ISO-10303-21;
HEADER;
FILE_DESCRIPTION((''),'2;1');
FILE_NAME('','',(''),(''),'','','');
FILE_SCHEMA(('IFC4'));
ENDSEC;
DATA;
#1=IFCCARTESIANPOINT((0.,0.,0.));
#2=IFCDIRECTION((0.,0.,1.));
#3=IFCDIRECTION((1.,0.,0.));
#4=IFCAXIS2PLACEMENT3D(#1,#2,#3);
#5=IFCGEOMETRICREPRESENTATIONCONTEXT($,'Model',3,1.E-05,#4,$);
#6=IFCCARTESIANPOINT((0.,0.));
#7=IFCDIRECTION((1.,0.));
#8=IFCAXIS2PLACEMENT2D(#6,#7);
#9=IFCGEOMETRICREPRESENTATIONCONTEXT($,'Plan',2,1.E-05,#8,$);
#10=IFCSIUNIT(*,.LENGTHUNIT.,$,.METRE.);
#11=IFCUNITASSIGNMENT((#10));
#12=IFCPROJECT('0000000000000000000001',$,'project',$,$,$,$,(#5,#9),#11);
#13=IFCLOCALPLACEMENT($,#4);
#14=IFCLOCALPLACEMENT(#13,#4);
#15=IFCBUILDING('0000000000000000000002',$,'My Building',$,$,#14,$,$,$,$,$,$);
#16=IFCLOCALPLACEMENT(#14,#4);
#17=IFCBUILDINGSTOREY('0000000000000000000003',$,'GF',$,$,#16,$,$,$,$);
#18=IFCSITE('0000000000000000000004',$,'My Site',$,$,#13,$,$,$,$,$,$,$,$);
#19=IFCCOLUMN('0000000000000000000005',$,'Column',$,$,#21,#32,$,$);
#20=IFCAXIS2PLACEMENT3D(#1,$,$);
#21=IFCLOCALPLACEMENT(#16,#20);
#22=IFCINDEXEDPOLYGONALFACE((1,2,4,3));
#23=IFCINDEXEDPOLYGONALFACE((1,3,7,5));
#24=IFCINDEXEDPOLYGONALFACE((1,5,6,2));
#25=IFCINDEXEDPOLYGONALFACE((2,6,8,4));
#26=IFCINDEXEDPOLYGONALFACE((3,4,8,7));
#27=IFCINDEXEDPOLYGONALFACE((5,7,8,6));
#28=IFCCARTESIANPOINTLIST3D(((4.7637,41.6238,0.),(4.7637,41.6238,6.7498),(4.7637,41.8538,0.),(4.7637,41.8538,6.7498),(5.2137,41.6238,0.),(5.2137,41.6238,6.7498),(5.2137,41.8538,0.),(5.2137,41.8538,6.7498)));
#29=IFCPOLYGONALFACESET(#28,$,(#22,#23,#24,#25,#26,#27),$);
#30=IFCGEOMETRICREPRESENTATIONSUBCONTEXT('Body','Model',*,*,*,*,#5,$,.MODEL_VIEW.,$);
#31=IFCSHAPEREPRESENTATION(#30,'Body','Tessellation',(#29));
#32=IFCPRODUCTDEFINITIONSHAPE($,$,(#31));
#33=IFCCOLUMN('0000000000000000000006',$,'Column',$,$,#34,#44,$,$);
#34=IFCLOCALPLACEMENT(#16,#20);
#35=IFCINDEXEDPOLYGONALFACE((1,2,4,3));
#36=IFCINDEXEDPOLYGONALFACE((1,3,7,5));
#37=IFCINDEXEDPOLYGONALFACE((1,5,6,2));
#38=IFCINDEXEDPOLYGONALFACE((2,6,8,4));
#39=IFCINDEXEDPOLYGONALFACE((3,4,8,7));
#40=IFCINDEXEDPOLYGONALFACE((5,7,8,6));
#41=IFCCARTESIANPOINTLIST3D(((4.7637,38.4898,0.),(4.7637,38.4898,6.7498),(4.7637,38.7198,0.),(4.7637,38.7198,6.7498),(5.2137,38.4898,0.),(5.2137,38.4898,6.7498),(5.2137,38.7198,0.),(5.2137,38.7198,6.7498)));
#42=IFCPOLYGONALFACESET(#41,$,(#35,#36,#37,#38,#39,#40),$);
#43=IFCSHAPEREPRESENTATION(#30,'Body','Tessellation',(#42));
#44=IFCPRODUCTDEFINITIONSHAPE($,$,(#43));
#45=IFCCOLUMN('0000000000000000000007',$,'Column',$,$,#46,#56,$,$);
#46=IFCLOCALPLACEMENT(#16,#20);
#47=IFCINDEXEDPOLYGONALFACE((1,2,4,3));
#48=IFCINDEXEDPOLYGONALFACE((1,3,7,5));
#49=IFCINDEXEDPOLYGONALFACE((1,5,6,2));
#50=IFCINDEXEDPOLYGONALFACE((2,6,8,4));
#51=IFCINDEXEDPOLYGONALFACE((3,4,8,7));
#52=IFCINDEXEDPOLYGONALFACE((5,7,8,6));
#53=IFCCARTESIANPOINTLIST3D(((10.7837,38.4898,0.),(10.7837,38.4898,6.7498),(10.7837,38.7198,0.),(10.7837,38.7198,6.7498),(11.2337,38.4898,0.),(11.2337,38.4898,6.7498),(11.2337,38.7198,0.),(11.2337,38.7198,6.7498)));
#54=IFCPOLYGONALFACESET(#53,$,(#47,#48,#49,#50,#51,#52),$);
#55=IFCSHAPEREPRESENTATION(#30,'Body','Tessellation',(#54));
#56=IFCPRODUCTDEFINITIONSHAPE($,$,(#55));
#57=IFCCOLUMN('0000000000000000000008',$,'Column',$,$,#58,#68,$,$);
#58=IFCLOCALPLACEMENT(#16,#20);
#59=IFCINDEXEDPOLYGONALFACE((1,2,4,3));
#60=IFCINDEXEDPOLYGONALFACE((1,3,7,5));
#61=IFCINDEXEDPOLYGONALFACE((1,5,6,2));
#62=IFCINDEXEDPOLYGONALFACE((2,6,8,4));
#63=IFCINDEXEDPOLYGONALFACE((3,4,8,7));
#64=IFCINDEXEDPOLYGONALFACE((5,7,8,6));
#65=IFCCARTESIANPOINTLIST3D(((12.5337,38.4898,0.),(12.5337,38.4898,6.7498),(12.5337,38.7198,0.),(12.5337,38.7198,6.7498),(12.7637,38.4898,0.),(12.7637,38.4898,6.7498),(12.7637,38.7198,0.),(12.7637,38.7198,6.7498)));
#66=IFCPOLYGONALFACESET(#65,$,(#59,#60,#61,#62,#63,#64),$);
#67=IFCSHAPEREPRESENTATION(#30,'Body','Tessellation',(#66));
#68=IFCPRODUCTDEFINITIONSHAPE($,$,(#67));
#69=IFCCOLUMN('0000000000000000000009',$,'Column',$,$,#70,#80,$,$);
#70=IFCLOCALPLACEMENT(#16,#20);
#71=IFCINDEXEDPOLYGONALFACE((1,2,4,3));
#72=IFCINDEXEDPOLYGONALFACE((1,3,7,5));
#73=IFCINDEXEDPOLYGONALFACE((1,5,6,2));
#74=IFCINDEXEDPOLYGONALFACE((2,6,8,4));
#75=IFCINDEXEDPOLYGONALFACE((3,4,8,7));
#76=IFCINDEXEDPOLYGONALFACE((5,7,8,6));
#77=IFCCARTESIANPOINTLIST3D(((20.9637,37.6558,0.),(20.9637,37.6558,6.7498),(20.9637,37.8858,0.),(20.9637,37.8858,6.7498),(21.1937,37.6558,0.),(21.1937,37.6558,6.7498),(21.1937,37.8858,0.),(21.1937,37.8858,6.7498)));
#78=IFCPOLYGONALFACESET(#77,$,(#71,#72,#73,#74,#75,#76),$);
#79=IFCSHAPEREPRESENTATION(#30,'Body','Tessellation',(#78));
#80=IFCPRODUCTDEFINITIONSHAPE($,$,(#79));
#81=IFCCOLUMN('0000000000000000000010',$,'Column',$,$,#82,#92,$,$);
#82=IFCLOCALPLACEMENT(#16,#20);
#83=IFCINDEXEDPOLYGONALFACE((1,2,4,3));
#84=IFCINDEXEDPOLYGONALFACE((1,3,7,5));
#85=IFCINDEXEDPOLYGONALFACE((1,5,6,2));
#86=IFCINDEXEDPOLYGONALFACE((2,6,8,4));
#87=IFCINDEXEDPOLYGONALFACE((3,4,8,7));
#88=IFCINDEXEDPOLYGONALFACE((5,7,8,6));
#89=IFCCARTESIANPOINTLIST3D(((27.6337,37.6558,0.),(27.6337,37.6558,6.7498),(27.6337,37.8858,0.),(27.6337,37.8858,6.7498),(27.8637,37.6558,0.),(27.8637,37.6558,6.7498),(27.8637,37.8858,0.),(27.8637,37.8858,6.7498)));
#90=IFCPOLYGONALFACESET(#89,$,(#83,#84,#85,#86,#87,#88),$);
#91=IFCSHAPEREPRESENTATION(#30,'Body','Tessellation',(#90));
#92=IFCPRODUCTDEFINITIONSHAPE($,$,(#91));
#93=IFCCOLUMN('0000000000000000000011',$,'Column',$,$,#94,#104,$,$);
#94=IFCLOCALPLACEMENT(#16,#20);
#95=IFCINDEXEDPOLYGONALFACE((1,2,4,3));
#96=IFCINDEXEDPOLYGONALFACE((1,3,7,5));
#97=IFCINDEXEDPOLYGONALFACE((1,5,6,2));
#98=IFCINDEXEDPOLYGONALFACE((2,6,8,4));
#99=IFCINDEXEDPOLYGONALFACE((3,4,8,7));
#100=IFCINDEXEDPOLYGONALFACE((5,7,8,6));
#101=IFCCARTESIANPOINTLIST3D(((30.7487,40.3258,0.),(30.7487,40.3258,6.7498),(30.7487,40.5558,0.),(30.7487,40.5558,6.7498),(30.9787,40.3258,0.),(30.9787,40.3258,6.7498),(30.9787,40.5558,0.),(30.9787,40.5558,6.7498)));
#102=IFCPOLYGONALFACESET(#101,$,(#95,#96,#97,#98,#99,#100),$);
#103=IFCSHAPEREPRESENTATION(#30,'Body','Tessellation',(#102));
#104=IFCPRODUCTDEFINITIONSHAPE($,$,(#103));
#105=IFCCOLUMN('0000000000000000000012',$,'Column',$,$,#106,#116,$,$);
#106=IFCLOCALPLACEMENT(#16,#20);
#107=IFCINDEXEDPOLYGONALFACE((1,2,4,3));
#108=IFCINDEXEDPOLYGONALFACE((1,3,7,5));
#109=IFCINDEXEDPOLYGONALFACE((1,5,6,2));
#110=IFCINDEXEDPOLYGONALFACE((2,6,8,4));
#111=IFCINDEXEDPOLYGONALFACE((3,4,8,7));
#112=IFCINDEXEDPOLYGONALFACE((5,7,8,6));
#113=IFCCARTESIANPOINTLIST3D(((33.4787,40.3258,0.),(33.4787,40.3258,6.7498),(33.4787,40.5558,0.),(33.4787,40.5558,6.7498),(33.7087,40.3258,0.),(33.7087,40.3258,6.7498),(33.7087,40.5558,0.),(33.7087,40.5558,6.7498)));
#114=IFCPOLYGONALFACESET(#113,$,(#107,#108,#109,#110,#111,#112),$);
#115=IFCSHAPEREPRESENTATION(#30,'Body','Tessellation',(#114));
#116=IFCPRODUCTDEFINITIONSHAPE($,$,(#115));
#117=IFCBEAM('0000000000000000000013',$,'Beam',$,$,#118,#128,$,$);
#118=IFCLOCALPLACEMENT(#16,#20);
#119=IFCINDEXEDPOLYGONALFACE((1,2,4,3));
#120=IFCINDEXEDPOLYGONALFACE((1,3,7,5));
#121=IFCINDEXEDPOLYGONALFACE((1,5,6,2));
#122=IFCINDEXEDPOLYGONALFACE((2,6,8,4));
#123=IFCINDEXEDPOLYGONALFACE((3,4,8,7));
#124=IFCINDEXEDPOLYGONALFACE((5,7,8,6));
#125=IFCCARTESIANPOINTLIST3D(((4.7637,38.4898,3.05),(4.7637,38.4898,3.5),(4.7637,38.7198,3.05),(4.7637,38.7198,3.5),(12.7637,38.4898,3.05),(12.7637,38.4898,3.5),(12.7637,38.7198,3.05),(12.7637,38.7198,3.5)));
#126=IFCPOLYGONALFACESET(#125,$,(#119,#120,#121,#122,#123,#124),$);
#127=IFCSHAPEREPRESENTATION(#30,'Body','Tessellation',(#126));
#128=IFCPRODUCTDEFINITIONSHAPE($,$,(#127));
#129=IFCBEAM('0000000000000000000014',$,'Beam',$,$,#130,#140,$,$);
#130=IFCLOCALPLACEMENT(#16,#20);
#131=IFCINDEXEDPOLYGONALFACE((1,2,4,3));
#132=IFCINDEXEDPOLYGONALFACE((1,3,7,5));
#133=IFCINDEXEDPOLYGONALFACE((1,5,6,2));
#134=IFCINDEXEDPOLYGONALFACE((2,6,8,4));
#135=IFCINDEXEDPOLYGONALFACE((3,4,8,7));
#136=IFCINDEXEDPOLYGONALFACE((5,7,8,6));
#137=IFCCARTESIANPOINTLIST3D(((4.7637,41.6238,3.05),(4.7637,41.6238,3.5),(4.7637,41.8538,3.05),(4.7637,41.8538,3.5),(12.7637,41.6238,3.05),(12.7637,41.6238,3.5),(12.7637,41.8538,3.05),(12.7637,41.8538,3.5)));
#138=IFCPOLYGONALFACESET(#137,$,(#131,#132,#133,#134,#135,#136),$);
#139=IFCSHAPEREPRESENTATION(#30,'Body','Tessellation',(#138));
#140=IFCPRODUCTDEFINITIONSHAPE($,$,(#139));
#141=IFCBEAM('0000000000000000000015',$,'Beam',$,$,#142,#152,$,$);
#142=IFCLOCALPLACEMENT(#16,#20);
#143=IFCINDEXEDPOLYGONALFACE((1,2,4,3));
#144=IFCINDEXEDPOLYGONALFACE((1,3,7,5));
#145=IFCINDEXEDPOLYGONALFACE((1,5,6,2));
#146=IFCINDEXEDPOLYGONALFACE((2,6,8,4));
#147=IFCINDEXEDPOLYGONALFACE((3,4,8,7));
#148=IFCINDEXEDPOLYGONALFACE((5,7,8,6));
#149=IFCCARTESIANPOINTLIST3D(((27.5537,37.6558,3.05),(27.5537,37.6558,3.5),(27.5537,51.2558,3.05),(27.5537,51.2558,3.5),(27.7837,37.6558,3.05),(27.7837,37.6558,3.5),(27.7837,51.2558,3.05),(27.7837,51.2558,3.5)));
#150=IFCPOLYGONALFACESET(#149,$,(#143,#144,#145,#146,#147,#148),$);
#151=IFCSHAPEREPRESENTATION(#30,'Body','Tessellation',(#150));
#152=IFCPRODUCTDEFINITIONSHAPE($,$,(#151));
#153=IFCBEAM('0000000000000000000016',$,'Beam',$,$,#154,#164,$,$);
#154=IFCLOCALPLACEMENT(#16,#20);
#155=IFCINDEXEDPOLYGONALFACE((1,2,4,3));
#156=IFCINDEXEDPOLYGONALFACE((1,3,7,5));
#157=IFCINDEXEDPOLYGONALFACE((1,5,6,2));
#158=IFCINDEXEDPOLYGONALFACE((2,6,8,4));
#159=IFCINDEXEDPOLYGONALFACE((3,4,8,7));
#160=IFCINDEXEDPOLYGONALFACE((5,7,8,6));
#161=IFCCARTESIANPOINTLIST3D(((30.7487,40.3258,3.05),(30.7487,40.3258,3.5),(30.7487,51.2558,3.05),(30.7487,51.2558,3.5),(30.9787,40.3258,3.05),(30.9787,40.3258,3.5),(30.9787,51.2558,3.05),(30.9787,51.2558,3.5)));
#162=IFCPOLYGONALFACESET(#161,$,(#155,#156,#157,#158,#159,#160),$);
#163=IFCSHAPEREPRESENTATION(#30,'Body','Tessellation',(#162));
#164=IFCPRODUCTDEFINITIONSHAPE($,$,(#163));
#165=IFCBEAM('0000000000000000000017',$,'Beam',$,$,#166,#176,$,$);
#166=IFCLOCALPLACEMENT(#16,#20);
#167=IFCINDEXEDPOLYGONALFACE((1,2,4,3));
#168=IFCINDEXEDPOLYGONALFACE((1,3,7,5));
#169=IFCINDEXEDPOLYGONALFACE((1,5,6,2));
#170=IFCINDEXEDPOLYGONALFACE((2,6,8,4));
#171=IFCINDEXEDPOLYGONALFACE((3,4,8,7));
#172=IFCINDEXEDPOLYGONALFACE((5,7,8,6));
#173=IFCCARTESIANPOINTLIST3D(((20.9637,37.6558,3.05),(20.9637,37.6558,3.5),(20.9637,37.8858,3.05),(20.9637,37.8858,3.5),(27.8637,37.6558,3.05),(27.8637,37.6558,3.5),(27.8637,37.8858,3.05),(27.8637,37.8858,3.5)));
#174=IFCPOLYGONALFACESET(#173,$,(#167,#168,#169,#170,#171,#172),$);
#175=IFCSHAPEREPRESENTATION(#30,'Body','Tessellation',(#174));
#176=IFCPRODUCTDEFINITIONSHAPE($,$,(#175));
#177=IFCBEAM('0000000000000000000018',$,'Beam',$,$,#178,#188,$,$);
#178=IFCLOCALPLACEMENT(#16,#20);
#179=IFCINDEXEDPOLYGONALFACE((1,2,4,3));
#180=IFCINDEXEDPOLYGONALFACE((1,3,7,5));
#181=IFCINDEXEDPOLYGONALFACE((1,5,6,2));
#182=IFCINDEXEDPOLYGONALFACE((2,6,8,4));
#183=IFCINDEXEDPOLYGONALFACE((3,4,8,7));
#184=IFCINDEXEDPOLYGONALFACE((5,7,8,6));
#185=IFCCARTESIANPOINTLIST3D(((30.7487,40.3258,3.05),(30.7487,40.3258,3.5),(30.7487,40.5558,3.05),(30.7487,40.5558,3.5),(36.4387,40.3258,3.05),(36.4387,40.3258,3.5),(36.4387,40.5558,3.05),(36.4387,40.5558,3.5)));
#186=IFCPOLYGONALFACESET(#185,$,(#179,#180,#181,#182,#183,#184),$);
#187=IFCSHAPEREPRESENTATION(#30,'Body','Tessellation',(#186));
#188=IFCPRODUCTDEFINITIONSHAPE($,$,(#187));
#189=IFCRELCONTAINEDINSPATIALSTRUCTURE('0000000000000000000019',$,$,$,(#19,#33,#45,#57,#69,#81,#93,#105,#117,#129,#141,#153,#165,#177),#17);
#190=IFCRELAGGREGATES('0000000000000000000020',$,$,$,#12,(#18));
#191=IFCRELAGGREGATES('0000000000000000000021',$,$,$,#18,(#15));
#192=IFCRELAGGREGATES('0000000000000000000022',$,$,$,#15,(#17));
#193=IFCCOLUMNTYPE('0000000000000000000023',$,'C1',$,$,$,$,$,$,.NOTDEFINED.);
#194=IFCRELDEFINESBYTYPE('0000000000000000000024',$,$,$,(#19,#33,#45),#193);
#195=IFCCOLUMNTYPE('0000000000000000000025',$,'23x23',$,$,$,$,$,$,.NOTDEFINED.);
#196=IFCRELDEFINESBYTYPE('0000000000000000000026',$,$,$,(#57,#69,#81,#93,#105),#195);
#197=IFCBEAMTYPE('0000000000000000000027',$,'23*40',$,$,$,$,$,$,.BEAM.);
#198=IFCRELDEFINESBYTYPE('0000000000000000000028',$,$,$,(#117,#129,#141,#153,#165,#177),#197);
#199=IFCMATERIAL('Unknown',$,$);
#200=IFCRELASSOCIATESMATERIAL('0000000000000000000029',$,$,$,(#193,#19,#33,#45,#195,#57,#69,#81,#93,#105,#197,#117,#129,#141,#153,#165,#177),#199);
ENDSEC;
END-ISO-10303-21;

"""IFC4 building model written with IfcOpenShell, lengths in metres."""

from ifc_helpers import new_model, si_unit, frame, origin_with_axes, origin_2d_with_axis, place, context, subcontext, project, spatial, rectangle, extrude, material, material_profile, profile_set, profile_usage, type_object, element, save


model = new_model("IFC4")

# Units and contexts
model_context = context("Model", 3, precision=1e-05, world=origin_with_axes())
plan_context = context("Plan", 2, precision=1e-05, world=origin_2d_with_axis())
body_context = subcontext(model_context, "Body", "Model", "MODEL_VIEW")
ifc_project = project(units=[si_unit("LENGTHUNIT", "METRE")], contexts=[model_context, plan_context])

# Site, building, storey
site_placement = place(None, origin_with_axes())
site = spatial("IfcSite", under=ifc_project, at=site_placement, Name="My Site")
building_placement = place(site_placement, origin_with_axes())
building = spatial("IfcBuilding", under=site, at=building_placement, Name="My Building")
storey_placement = place(building_placement, origin_with_axes())
storey = spatial("IfcBuildingStorey", under=building, at=storey_placement, Name="GF")

# Columns
ifc_material = material(Name="Unknown")
ifc_material_profile_1 = material_profile(ifc_material, rectangle(XDim=0.45, YDim=0.23))
ifc_profile_set_1 = profile_set([ifc_material_profile_1])
ifc_profile_usage_1 = profile_usage(ifc_profile_set_1, cardinal=5)
column_type_1 = type_object("IfcColumnType", Name="C1", PredefinedType="NOTDEFINED", material=ifc_profile_set_1)
column_1_placement = place(storey_placement, frame((4.9887, 41.7388, 0.0), z_axis=(0.0, 0.0, 1.0), x_axis=(1.0, 0.0, 0.0)))
element("IfcColumn", 1, at=column_1_placement, inside=storey, type_object=column_type_1, material=ifc_profile_usage_1, Name="Column", context=body_context, shape_type="SweptSolid", body=[
    extrude(rectangle(XDim=0.45, YDim=0.23), origin_with_axes(), (0.0, 0.0, 1.0), 6.7498),
])
ifc_profile_usage_2 = profile_usage(ifc_profile_set_1, cardinal=5)
column_2_placement = place(storey_placement, frame((4.9887, 38.6048, 0.0), z_axis=(0.0, 0.0, 1.0), x_axis=(1.0, 0.0, 0.0)))
element("IfcColumn", 2, at=column_2_placement, inside=storey, type_object=column_type_1, material=ifc_profile_usage_2, Name="Column", context=body_context, shape_type="SweptSolid", body=[
    extrude(rectangle(XDim=0.45, YDim=0.23), origin_with_axes(), (0.0, 0.0, 1.0), 6.7498),
])
ifc_profile_usage_3 = profile_usage(ifc_profile_set_1, cardinal=5)
column_3_placement = place(storey_placement, frame((11.0087, 38.6048, 0.0), z_axis=(0.0, 0.0, 1.0), x_axis=(-1.0, 0.0, 0.0)))
element("IfcColumn", 3, at=column_3_placement, inside=storey, type_object=column_type_1, material=ifc_profile_usage_3, Name="Column", context=body_context, shape_type="SweptSolid", body=[
    extrude(rectangle(XDim=0.45, YDim=0.23), origin_with_axes(), (0.0, 0.0, 1.0), 6.7498),
])
ifc_material_profile_2 = material_profile(ifc_material, rectangle(XDim=0.23, YDim=0.23))
ifc_profile_set_2 = profile_set([ifc_material_profile_2])
ifc_profile_usage_4 = profile_usage(ifc_profile_set_2, cardinal=5)
column_type_2 = type_object("IfcColumnType", Name="23x23", PredefinedType="NOTDEFINED", material=ifc_profile_set_2)
column_4_placement = place(storey_placement, frame((12.6487, 38.6048, 0.0), z_axis=(0.0, 0.0, 1.0), x_axis=(1.0, 0.0, 0.0)))
element("IfcColumn", 4, at=column_4_placement, inside=storey, type_object=column_type_2, material=ifc_profile_usage_4, Name="Column", context=body_context, shape_type="SweptSolid", body=[
    extrude(rectangle(XDim=0.23, YDim=0.23), origin_with_axes(), (0.0, 0.0, 1.0), 6.7498),
])
ifc_profile_usage_5 = profile_usage(ifc_profile_set_2, cardinal=5)
column_5_placement = place(storey_placement, frame((21.0787, 37.7708, 0.0), z_axis=(0.0, 0.0, 1.0), x_axis=(1.0, 0.0, 0.0)))
element("IfcColumn", 5, at=column_5_placement, inside=storey, type_object=column_type_2, material=ifc_profile_usage_5, Name="Column", context=body_context, shape_type="SweptSolid", body=[
    extrude(rectangle(XDim=0.23, YDim=0.23), origin_with_axes(), (0.0, 0.0, 1.0), 6.7498),
])
ifc_profile_usage_6 = profile_usage(ifc_profile_set_2, cardinal=5)
column_6_placement = place(storey_placement, frame((27.7487, 37.7708, 0.0), z_axis=(0.0, 0.0, 1.0), x_axis=(1.0, 0.0, 0.0)))
element("IfcColumn", 6, at=column_6_placement, inside=storey, type_object=column_type_2, material=ifc_profile_usage_6, Name="Column", context=body_context, shape_type="SweptSolid", body=[
    extrude(rectangle(XDim=0.23, YDim=0.23), origin_with_axes(), (0.0, 0.0, 1.0), 6.7498),
])
ifc_profile_usage_7 = profile_usage(ifc_profile_set_2, cardinal=5)
column_7_placement = place(storey_placement, frame((30.8637, 40.4408, 0.0), z_axis=(0.0, 0.0, 1.0), x_axis=(1.0, 0.0, 0.0)))
element("IfcColumn", 7, at=column_7_placement, inside=storey, type_object=column_type_2, material=ifc_profile_usage_7, Name="Column", context=body_context, shape_type="SweptSolid", body=[
    extrude(rectangle(XDim=0.23, YDim=0.23), origin_with_axes(), (0.0, 0.0, 1.0), 6.7498),
])
ifc_profile_usage_8 = profile_usage(ifc_profile_set_2, cardinal=5)
column_8_placement = place(storey_placement, frame((33.5937, 40.4408, 0.0), z_axis=(0.0, 0.0, 1.0), x_axis=(1.0, 0.0, 0.0)))
element("IfcColumn", 8, at=column_8_placement, inside=storey, type_object=column_type_2, material=ifc_profile_usage_8, Name="Column", context=body_context, shape_type="SweptSolid", body=[
    extrude(rectangle(XDim=0.23, YDim=0.23), origin_with_axes(), (0.0, 0.0, 1.0), 6.7498),
])

# Beams
ifc_material_profile_3 = material_profile(ifc_material, rectangle(XDim=0.23, YDim=0.45))
ifc_profile_set_3 = profile_set([ifc_material_profile_3])
ifc_profile_usage_9 = profile_usage(ifc_profile_set_3, cardinal=5)
beam_type = type_object("IfcBeamType", Name="23*40", PredefinedType="BEAM", material=ifc_profile_set_3)
beam_1_placement = place(storey_placement, frame((4.7637, 38.6048, 3.275), z_axis=(1.0, 0.0, 0.0), x_axis=(0.0, 1.0, 0.0)))
element("IfcBeam", 9, at=beam_1_placement, inside=storey, type_object=beam_type, material=ifc_profile_usage_9, Name="Beam", context=body_context, shape_type="SweptSolid", body=[
    extrude(rectangle(XDim=0.23, YDim=0.45), origin_with_axes(), (0.0, 0.0, 1.0), 8.0),
])
ifc_profile_usage_10 = profile_usage(ifc_profile_set_3, cardinal=5)
beam_2_placement = place(storey_placement, frame((4.7637, 41.7388, 3.275), z_axis=(1.0, 0.0, 0.0), x_axis=(0.0, 1.0, 0.0)))
element("IfcBeam", 10, at=beam_2_placement, inside=storey, type_object=beam_type, material=ifc_profile_usage_10, Name="Beam", context=body_context, shape_type="SweptSolid", body=[
    extrude(rectangle(XDim=0.23, YDim=0.45), origin_with_axes(), (0.0, 0.0, 1.0), 8.0),
])
ifc_profile_usage_11 = profile_usage(ifc_profile_set_3, cardinal=5)
beam_3_placement = place(storey_placement, frame((27.6687, 37.6558, 3.275), z_axis=(0.0, 1.0, 0.0), x_axis=(-1.0, 0.0, 0.0)))
element("IfcBeam", 11, at=beam_3_placement, inside=storey, type_object=beam_type, material=ifc_profile_usage_11, Name="Beam", context=body_context, shape_type="SweptSolid", body=[
    extrude(rectangle(XDim=0.23, YDim=0.45), origin_with_axes(), (0.0, 0.0, 1.0), 13.6),
])
ifc_profile_usage_12 = profile_usage(ifc_profile_set_3, cardinal=5)
beam_4_placement = place(storey_placement, frame((30.8637, 40.3258, 3.275), z_axis=(0.0, 1.0, 0.0), x_axis=(-1.0, 0.0, 0.0)))
element("IfcBeam", 12, at=beam_4_placement, inside=storey, type_object=beam_type, material=ifc_profile_usage_12, Name="Beam", context=body_context, shape_type="SweptSolid", body=[
    extrude(rectangle(XDim=0.23, YDim=0.45), origin_with_axes(), (0.0, 0.0, 1.0), 10.93),
])
ifc_profile_usage_13 = profile_usage(ifc_profile_set_3, cardinal=5)
beam_5_placement = place(storey_placement, frame((20.9637, 37.7708, 3.275), z_axis=(1.0, 0.0, 0.0), x_axis=(0.0, 1.0, 0.0)))
element("IfcBeam", 13, at=beam_5_placement, inside=storey, type_object=beam_type, material=ifc_profile_usage_13, Name="Beam", context=body_context, shape_type="SweptSolid", body=[
    extrude(rectangle(XDim=0.23, YDim=0.45), origin_with_axes(), (0.0, 0.0, 1.0), 6.9),
])
ifc_profile_usage_14 = profile_usage(ifc_profile_set_3, cardinal=5)
beam_6_placement = place(storey_placement, frame((30.7487, 40.4408, 3.275), z_axis=(1.0, 0.0, 0.0), x_axis=(0.0, 1.0, 0.0)))
element("IfcBeam", 14, at=beam_6_placement, inside=storey, type_object=beam_type, material=ifc_profile_usage_14, Name="Beam", context=body_context, shape_type="SweptSolid", body=[
    extrude(rectangle(XDim=0.23, YDim=0.45), origin_with_axes(), (0.0, 0.0, 1.0), 5.69),
])

save(model, "model.ifc")
